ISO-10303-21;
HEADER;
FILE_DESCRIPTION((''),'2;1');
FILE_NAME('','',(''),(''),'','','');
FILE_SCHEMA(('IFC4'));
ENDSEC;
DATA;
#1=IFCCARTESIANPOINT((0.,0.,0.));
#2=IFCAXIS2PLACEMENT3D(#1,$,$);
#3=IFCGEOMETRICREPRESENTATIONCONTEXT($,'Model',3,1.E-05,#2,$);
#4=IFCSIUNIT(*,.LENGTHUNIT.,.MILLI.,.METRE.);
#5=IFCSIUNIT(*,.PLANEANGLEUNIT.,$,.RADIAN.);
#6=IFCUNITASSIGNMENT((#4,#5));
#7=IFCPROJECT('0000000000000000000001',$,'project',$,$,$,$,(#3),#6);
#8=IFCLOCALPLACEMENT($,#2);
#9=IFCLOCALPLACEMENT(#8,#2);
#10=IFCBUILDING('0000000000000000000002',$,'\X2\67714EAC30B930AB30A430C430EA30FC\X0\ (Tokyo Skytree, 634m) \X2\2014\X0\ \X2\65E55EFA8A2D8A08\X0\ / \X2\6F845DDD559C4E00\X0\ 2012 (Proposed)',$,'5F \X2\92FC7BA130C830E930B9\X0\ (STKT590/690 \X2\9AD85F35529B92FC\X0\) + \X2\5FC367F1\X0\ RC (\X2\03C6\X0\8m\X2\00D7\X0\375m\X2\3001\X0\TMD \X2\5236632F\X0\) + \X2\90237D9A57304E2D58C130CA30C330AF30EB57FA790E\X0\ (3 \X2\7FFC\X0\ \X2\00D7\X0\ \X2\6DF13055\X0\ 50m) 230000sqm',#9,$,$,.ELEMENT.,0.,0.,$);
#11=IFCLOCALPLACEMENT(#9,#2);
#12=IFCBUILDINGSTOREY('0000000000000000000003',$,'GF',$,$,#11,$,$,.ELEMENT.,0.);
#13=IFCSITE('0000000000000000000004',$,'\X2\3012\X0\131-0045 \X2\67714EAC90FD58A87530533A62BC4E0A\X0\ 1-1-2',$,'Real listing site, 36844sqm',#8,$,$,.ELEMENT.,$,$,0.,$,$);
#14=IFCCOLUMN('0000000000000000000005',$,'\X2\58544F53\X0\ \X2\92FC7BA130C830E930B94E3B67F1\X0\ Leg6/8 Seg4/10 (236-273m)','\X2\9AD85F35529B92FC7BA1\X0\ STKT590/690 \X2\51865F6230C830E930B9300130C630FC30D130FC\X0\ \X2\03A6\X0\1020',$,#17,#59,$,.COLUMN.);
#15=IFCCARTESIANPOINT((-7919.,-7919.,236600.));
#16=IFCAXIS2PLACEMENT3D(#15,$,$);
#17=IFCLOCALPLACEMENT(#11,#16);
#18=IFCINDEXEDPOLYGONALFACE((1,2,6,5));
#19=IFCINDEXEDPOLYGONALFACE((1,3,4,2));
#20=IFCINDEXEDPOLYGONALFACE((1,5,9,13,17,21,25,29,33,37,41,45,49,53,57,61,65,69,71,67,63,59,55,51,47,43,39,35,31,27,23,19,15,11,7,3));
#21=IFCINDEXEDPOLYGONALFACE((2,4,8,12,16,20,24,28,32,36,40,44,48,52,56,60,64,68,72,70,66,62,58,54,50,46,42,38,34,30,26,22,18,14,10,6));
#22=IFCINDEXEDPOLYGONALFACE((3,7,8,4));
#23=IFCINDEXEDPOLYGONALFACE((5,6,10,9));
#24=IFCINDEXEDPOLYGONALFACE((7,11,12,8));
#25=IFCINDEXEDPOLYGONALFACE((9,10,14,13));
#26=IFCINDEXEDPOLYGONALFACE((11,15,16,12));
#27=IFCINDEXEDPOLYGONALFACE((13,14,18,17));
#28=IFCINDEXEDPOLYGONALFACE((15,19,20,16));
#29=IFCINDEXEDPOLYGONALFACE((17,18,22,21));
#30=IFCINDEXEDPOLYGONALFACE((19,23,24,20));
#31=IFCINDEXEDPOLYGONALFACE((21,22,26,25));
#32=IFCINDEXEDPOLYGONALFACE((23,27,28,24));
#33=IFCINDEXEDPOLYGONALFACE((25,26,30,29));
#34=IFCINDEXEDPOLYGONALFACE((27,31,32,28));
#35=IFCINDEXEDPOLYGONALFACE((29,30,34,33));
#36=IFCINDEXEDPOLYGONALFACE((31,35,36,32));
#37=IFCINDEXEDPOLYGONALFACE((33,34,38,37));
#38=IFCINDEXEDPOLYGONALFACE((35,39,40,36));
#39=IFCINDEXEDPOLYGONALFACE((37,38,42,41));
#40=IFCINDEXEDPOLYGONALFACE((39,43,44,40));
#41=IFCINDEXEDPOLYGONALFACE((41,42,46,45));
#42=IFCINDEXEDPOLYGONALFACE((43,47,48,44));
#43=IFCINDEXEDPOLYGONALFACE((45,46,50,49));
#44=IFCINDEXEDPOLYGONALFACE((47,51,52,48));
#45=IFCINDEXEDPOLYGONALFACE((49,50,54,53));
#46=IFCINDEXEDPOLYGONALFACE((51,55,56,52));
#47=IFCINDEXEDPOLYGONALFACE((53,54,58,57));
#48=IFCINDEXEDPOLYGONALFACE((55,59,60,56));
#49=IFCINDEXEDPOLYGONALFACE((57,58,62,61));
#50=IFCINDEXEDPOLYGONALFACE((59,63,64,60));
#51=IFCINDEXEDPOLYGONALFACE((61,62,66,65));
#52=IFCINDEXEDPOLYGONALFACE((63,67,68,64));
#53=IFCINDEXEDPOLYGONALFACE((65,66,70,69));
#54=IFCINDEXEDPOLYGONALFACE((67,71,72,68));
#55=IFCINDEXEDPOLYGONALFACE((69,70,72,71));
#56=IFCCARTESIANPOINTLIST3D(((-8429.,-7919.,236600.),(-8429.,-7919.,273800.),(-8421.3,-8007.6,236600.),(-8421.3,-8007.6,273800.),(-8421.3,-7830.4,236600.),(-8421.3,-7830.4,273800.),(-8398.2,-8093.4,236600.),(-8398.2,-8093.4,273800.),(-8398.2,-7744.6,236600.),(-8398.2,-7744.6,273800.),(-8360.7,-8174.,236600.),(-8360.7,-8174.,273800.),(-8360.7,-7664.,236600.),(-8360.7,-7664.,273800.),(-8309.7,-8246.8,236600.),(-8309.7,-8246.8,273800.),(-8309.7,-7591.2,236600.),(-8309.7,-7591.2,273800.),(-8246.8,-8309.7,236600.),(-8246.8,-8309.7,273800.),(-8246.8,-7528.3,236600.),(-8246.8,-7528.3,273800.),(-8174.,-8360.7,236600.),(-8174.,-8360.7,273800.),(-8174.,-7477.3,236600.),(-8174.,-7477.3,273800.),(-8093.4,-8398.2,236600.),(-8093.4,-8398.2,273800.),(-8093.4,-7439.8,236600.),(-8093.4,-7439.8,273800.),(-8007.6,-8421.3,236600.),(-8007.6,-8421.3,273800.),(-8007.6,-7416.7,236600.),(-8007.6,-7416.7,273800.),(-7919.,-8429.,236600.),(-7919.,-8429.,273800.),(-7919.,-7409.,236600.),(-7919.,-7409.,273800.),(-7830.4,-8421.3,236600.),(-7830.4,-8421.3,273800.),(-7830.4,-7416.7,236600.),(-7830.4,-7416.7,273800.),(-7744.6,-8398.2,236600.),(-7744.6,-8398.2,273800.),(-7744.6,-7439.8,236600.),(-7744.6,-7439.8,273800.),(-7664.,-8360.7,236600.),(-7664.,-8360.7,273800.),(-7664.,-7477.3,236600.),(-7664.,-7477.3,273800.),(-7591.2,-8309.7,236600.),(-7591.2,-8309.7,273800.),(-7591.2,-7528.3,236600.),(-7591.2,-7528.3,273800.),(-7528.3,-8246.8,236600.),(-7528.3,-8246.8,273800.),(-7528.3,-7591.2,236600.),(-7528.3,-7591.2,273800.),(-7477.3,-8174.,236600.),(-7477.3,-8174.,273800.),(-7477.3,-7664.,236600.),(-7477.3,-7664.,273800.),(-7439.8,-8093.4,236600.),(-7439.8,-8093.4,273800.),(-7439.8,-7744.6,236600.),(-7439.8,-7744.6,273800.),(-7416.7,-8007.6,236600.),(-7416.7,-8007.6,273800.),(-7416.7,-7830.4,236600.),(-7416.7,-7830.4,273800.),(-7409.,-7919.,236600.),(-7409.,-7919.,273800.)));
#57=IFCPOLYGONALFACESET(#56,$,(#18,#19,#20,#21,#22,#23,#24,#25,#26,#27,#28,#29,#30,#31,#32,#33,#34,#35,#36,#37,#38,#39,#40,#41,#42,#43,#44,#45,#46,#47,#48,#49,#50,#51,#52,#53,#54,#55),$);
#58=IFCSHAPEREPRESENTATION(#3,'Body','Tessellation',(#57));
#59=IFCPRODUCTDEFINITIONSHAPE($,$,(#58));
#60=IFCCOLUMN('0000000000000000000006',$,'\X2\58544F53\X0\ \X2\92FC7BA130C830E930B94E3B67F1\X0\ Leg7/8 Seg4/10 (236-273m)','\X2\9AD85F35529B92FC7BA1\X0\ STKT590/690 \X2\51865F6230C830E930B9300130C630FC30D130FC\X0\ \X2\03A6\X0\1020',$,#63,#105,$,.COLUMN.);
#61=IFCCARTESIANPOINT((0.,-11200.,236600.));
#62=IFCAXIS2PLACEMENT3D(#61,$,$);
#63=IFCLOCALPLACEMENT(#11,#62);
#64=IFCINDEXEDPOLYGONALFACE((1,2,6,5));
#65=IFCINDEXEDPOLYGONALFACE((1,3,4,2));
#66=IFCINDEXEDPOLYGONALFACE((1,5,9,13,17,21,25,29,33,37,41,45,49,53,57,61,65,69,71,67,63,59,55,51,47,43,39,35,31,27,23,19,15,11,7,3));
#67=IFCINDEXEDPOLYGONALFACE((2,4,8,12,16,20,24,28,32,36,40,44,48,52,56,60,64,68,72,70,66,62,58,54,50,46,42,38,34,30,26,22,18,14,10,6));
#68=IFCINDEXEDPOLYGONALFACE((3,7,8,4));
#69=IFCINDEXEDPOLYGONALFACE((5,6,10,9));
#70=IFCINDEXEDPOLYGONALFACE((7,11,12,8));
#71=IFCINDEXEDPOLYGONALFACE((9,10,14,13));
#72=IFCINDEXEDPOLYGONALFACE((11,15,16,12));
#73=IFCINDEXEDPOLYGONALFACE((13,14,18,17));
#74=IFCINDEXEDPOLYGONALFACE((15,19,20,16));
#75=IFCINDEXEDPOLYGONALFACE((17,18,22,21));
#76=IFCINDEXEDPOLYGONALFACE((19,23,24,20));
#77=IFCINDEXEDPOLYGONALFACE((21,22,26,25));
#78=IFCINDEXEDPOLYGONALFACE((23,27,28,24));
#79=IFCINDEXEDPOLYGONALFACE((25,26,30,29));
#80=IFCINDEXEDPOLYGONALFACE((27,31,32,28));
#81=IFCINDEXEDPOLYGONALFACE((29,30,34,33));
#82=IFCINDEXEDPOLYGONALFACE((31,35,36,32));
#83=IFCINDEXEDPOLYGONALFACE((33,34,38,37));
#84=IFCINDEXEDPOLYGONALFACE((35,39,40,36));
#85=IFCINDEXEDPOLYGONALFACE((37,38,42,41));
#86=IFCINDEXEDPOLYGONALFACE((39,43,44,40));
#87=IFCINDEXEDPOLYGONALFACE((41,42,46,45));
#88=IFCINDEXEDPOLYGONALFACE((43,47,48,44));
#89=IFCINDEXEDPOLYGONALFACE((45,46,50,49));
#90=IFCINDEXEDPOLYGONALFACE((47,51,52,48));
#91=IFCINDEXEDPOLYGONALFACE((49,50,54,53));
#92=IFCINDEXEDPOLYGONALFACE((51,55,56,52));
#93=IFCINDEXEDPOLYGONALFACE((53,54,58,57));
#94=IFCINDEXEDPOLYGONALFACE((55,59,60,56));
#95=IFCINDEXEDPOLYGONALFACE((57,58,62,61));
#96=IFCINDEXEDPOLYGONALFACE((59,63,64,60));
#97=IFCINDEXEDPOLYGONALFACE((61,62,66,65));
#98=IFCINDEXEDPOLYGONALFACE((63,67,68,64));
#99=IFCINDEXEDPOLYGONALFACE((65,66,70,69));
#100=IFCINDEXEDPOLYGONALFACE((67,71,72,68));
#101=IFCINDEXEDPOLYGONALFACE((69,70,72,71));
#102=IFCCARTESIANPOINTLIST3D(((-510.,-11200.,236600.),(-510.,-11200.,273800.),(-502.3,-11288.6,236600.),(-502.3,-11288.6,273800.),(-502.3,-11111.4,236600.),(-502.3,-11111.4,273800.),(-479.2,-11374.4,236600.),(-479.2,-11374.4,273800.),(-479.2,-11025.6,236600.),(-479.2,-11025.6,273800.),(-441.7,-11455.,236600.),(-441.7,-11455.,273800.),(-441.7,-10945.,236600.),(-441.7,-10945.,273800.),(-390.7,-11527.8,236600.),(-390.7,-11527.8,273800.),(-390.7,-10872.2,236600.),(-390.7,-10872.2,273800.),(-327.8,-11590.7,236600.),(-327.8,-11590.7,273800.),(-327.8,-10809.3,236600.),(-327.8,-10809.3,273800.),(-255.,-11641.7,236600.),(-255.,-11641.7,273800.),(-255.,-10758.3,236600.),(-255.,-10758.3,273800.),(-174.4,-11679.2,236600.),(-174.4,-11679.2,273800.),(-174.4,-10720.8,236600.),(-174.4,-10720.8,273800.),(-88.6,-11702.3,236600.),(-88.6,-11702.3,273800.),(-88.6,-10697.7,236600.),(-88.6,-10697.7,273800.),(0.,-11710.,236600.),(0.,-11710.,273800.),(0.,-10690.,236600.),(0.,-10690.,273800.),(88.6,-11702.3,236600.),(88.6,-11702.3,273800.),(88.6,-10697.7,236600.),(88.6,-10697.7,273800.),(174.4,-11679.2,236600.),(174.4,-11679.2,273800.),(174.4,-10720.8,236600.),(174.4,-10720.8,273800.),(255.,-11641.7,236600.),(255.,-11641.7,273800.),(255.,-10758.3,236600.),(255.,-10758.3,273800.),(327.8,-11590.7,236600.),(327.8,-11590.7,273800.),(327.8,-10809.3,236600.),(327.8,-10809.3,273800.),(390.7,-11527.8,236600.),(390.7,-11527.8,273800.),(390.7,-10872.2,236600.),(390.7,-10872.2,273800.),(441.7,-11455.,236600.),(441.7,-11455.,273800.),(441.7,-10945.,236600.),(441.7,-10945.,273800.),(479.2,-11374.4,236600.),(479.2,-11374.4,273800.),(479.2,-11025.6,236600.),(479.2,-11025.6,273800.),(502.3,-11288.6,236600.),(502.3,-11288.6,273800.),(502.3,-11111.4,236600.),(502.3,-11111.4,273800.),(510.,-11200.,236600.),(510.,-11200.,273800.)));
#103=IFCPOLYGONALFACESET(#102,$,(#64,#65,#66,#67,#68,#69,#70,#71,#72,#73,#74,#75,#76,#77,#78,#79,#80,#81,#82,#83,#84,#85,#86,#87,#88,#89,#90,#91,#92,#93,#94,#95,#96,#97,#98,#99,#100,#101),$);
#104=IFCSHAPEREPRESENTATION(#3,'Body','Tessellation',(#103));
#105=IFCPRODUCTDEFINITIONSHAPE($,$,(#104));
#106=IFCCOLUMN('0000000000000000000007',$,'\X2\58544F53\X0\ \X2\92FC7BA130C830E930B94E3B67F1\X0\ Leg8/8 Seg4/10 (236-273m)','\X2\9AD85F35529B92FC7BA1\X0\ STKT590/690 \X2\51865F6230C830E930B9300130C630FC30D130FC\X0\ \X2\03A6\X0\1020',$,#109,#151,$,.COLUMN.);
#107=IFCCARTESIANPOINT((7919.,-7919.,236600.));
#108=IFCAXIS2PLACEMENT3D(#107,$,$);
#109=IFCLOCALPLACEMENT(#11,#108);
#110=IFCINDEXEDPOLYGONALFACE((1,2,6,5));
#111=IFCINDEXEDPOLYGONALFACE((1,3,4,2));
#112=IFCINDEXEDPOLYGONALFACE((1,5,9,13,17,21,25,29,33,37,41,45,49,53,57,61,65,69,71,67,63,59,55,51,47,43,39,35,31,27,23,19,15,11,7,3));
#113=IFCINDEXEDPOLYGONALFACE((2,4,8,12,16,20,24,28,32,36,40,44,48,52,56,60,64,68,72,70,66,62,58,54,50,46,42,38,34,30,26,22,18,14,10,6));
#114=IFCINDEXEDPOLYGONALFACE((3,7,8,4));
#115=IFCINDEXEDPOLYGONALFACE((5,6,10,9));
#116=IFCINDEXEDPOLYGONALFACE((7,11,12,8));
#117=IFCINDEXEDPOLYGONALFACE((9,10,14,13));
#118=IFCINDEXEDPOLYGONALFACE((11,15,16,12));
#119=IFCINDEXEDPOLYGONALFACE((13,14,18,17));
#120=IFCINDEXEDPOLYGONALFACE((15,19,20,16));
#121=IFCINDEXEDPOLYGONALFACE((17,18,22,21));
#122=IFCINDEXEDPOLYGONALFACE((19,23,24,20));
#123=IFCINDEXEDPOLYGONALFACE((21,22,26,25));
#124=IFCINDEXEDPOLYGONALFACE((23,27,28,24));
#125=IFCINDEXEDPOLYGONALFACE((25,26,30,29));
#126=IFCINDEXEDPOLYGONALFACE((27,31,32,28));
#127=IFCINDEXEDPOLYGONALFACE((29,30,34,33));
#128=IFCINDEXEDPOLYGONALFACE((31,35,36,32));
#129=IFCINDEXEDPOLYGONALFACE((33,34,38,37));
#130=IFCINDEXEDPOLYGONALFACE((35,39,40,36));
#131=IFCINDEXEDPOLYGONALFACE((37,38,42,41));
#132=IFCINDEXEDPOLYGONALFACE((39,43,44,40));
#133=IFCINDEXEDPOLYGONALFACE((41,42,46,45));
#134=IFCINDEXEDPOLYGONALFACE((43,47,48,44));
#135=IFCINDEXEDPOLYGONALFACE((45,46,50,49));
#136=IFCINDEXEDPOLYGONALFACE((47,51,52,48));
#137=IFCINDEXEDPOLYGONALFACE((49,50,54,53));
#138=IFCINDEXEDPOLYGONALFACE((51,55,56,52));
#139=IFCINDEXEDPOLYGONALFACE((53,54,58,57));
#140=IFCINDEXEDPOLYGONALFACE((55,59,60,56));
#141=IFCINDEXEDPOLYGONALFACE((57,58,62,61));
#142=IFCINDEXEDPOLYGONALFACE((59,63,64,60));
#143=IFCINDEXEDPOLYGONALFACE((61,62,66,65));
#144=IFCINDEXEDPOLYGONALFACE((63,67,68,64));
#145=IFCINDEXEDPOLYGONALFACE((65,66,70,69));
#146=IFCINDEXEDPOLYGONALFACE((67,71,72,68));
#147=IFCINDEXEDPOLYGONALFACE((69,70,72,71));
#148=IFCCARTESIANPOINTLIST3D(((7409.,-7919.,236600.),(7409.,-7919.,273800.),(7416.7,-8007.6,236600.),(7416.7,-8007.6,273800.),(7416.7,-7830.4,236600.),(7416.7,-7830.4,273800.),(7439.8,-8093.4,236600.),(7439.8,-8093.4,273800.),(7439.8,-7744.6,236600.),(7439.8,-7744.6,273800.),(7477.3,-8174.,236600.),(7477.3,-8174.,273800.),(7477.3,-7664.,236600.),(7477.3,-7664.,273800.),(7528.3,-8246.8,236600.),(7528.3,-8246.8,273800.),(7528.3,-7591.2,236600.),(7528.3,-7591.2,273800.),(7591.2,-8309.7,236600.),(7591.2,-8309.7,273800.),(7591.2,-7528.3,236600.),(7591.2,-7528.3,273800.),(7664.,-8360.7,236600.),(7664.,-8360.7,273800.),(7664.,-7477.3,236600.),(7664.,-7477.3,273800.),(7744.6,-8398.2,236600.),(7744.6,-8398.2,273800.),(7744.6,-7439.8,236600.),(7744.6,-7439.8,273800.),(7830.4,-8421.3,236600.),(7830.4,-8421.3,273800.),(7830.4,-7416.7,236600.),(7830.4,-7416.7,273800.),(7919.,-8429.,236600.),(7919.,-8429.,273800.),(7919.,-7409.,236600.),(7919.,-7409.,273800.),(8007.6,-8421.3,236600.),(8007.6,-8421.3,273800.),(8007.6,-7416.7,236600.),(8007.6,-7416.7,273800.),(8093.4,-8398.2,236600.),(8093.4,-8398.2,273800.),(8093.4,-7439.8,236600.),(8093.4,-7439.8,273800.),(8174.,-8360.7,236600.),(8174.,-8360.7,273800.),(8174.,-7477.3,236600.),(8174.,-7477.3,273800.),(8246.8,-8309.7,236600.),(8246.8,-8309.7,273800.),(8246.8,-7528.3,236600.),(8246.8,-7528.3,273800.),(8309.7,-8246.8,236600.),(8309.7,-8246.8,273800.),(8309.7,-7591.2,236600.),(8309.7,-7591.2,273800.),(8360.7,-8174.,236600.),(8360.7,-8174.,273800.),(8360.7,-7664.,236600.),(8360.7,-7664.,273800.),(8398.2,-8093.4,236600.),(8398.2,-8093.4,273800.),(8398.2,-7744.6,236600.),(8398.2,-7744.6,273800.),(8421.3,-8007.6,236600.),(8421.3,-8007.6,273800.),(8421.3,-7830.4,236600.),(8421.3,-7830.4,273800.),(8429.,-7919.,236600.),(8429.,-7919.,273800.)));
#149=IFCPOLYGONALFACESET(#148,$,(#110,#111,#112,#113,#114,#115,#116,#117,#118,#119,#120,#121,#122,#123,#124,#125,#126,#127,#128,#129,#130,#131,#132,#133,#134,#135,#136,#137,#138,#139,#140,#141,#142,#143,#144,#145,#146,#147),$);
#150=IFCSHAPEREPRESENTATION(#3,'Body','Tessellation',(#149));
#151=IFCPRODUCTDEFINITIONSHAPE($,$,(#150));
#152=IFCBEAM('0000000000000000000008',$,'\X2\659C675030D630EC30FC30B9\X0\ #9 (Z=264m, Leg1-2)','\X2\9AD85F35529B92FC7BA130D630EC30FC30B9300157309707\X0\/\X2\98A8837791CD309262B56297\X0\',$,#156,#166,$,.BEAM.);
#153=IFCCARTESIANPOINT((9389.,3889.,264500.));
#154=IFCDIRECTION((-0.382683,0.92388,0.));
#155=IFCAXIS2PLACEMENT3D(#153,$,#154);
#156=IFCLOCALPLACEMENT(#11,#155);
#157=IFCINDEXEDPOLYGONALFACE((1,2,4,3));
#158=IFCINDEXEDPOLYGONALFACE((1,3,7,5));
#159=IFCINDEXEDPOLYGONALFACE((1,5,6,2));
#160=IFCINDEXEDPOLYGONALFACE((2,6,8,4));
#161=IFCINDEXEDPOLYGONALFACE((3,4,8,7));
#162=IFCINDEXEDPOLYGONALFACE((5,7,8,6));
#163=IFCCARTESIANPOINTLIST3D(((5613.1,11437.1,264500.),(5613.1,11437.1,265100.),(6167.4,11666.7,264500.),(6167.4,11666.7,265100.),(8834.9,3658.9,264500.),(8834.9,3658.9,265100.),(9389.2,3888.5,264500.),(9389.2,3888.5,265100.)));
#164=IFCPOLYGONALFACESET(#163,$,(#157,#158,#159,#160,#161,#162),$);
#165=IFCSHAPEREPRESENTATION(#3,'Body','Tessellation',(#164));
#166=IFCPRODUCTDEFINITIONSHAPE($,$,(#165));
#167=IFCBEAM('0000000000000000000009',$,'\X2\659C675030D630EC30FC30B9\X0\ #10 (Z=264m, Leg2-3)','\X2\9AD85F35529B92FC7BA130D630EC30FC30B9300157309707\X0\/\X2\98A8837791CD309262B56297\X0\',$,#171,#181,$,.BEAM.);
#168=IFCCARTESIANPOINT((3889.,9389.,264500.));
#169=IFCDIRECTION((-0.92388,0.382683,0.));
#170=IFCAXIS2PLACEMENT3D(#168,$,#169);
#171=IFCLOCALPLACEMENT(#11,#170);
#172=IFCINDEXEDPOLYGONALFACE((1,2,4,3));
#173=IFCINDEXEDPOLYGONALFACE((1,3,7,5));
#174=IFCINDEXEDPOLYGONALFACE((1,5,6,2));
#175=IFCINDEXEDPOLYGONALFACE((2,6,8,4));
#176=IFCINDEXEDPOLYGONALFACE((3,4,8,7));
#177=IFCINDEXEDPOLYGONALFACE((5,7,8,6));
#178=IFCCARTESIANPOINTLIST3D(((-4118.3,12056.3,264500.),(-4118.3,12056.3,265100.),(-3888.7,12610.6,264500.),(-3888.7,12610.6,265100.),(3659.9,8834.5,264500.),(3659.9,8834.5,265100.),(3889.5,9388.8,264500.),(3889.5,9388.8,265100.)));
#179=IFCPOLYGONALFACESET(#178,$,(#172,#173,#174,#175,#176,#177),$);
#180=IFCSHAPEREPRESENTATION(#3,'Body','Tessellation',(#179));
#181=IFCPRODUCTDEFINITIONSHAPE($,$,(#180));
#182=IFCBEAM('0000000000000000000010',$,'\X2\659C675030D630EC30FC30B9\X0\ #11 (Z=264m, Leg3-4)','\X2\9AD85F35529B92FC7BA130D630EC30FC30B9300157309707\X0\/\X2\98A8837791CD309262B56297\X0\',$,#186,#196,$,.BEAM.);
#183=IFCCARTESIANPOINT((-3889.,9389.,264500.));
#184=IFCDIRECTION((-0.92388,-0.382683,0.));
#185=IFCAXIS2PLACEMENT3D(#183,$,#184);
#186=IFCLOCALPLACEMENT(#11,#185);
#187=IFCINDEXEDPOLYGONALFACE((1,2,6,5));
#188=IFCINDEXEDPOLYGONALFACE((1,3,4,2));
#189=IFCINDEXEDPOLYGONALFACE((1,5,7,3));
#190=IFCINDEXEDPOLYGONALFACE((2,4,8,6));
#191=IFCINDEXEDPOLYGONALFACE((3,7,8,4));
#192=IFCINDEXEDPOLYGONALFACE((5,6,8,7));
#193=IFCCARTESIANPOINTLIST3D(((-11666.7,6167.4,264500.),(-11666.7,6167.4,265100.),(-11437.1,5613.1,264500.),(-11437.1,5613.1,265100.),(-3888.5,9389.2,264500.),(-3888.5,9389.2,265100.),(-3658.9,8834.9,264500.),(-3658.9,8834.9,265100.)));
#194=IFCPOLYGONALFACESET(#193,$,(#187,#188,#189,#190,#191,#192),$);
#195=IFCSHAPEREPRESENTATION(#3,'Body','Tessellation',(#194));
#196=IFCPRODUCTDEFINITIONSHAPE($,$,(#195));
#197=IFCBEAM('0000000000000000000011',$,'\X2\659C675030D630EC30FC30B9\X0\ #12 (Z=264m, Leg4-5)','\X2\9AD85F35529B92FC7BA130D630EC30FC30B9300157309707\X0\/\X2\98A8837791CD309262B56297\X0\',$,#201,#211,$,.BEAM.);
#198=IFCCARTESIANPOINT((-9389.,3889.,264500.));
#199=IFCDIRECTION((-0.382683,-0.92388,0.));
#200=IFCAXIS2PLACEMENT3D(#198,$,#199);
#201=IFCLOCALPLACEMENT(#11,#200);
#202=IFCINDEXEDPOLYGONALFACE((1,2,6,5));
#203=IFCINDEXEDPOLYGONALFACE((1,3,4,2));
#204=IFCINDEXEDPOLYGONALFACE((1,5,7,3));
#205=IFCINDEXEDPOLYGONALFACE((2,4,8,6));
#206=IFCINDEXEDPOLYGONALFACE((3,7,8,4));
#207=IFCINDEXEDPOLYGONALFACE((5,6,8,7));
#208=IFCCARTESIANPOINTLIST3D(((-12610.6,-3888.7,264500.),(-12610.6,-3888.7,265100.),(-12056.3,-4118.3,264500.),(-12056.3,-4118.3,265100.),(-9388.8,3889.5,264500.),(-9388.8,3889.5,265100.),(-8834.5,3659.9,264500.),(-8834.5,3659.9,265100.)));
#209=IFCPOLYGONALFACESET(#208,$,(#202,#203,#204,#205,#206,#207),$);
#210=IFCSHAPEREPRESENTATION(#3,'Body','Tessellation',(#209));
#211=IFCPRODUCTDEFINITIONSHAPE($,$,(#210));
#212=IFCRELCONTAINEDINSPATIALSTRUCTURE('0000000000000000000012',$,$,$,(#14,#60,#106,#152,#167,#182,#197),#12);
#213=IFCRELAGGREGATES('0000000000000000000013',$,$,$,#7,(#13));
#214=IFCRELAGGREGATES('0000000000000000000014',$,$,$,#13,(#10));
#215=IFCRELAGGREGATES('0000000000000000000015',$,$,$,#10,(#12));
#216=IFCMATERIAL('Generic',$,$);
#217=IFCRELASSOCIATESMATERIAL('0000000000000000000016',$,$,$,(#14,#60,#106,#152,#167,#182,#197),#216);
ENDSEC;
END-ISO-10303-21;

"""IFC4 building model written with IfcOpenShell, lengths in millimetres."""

from ifc_helpers import new_model, si_unit, frame, frame_2d, origin, origin_2d, place, context, project, spatial, rectangle, circle, extrude, material, element, save


model = new_model("IFC4")

# Units and contexts
model_context = context("Model", 3, precision=1e-05, world=origin())
ifc_project = project(units=[si_unit("LENGTHUNIT", "METRE", prefix="MILLI"), si_unit("PLANEANGLEUNIT", "RADIAN")], contexts=[model_context])

# Site, building, storey
site_placement = place(None, origin())
site = spatial("IfcSite", under=ifc_project, at=site_placement, Name="〒131-0045 東京都墨田区押上 1-1-2", ObjectType="Real listing site, 36844sqm", CompositionType="ELEMENT", RefElevation=0.0)
building_placement = place(site_placement, origin())
building = spatial("IfcBuilding", under=site, at=building_placement, Name="東京スカイツリー (Tokyo Skytree, 634m) — 日建設計 / 澄川喜一 2012 (Proposed)", ObjectType="5F 鋼管トラス (STKT590/690 高張力鋼) + 心柱 RC (φ8m×375m、TMD 制振) + 連続地中壁ナックル基礎 (3 翼 × 深さ 50m) 230000sqm", CompositionType="ELEMENT", ElevationOfRefHeight=0.0, ElevationOfTerrain=0.0)
storey_placement = place(building_placement, origin())
storey = spatial("IfcBuildingStorey", under=building, at=storey_placement, Name="GF", CompositionType="ELEMENT", Elevation=0.0)

# Columns
ifc_material_1 = material(Name="Generic")
column_1_placement = place(storey_placement, frame((-7919.0, -7919.0, 236600.0)))
element("IfcColumn", 1, at=column_1_placement, inside=storey, material=ifc_material_1, Name="塔体 鋼管トラス主柱 Leg6/8 Seg4/10 (236-273m)", Description="高張力鋼管 STKT590/690 円形トラス、テーパー Φ1020", PredefinedType="COLUMN", context=model_context, shape_type="SweptSolid", body=[
    extrude(circle(Radius=510.0, at=origin_2d()), frame((-7919.0, -7919.0, 236600.0)), (0.0, 0.0, 1.0), 37200.0),
])
column_2_placement = place(storey_placement, frame((0.0, -11200.0, 236600.0)))
element("IfcColumn", 2, at=column_2_placement, inside=storey, material=ifc_material_1, Name="塔体 鋼管トラス主柱 Leg7/8 Seg4/10 (236-273m)", Description="高張力鋼管 STKT590/690 円形トラス、テーパー Φ1020", PredefinedType="COLUMN", context=model_context, shape_type="SweptSolid", body=[
    extrude(circle(Radius=510.0, at=origin_2d()), frame((0.0, -11200.0, 236600.0)), (0.0, 0.0, 1.0), 37200.0),
])
column_3_placement = place(storey_placement, frame((7919.0, -7919.0, 236600.0)))
element("IfcColumn", 3, at=column_3_placement, inside=storey, material=ifc_material_1, Name="塔体 鋼管トラス主柱 Leg8/8 Seg4/10 (236-273m)", Description="高張力鋼管 STKT590/690 円形トラス、テーパー Φ1020", PredefinedType="COLUMN", context=model_context, shape_type="SweptSolid", body=[
    extrude(circle(Radius=510.0, at=origin_2d()), frame((7919.0, -7919.0, 236600.0)), (0.0, 0.0, 1.0), 37200.0),
])

# Beams
beam_1_placement = place(storey_placement, frame((9389.0, 3889.0, 264500.0), x_axis=(-0.382683, 0.92388, 0.0)))
element("IfcBeam", 4, at=beam_1_placement, inside=storey, material=ifc_material_1, Name="斜材ブレース #9 (Z=264m, Leg1-2)", Description="高張力鋼管ブレース、地震/風荷重を抵抗", PredefinedType="BEAM", context=model_context, shape_type="SweptSolid", body=[
    extrude(rectangle(XDim=8419.0, YDim=600.0, at=frame_2d((4209.0, 300.0))), frame((9389.0, 3889.0, 264500.0), x_axis=(-0.382683, 0.92388, 0.0)), (0.0, 0.0, 1.0), 600.0),
])
beam_2_placement = place(storey_placement, frame((3889.0, 9389.0, 264500.0), x_axis=(-0.92388, 0.382683, 0.0)))
element("IfcBeam", 5, at=beam_2_placement, inside=storey, material=ifc_material_1, Name="斜材ブレース #10 (Z=264m, Leg2-3)", Description="高張力鋼管ブレース、地震/風荷重を抵抗", PredefinedType="BEAM", context=model_context, shape_type="SweptSolid", body=[
    extrude(rectangle(XDim=8419.0, YDim=600.0, at=frame_2d((4209.0, 300.0))), frame((3889.0, 9389.0, 264500.0), x_axis=(-0.92388, 0.382683, 0.0)), (0.0, 0.0, 1.0), 600.0),
])
beam_3_placement = place(storey_placement, frame((-3889.0, 9389.0, 264500.0), x_axis=(-0.92388, -0.382683, 0.0)))
element("IfcBeam", 6, at=beam_3_placement, inside=storey, material=ifc_material_1, Name="斜材ブレース #11 (Z=264m, Leg3-4)", Description="高張力鋼管ブレース、地震/風荷重を抵抗", PredefinedType="BEAM", context=model_context, shape_type="SweptSolid", body=[
    extrude(rectangle(XDim=8419.0, YDim=600.0, at=frame_2d((4209.0, 300.0))), frame((-3889.0, 9389.0, 264500.0), x_axis=(-0.92388, -0.382683, 0.0)), (0.0, 0.0, 1.0), 600.0),
])
beam_4_placement = place(storey_placement, frame((-9389.0, 3889.0, 264500.0), x_axis=(-0.382683, -0.92388, 0.0)))
element("IfcBeam", 7, at=beam_4_placement, inside=storey, material=ifc_material_1, Name="斜材ブレース #12 (Z=264m, Leg4-5)", Description="高張力鋼管ブレース、地震/風荷重を抵抗", PredefinedType="BEAM", context=model_context, shape_type="SweptSolid", body=[
    extrude(rectangle(XDim=8419.0, YDim=600.0, at=frame_2d((4209.0, 300.0))), frame((-9389.0, 3889.0, 264500.0), x_axis=(-0.382683, -0.92388, 0.0)), (0.0, 0.0, 1.0), 600.0),
])

save(model, "model.ifc")
